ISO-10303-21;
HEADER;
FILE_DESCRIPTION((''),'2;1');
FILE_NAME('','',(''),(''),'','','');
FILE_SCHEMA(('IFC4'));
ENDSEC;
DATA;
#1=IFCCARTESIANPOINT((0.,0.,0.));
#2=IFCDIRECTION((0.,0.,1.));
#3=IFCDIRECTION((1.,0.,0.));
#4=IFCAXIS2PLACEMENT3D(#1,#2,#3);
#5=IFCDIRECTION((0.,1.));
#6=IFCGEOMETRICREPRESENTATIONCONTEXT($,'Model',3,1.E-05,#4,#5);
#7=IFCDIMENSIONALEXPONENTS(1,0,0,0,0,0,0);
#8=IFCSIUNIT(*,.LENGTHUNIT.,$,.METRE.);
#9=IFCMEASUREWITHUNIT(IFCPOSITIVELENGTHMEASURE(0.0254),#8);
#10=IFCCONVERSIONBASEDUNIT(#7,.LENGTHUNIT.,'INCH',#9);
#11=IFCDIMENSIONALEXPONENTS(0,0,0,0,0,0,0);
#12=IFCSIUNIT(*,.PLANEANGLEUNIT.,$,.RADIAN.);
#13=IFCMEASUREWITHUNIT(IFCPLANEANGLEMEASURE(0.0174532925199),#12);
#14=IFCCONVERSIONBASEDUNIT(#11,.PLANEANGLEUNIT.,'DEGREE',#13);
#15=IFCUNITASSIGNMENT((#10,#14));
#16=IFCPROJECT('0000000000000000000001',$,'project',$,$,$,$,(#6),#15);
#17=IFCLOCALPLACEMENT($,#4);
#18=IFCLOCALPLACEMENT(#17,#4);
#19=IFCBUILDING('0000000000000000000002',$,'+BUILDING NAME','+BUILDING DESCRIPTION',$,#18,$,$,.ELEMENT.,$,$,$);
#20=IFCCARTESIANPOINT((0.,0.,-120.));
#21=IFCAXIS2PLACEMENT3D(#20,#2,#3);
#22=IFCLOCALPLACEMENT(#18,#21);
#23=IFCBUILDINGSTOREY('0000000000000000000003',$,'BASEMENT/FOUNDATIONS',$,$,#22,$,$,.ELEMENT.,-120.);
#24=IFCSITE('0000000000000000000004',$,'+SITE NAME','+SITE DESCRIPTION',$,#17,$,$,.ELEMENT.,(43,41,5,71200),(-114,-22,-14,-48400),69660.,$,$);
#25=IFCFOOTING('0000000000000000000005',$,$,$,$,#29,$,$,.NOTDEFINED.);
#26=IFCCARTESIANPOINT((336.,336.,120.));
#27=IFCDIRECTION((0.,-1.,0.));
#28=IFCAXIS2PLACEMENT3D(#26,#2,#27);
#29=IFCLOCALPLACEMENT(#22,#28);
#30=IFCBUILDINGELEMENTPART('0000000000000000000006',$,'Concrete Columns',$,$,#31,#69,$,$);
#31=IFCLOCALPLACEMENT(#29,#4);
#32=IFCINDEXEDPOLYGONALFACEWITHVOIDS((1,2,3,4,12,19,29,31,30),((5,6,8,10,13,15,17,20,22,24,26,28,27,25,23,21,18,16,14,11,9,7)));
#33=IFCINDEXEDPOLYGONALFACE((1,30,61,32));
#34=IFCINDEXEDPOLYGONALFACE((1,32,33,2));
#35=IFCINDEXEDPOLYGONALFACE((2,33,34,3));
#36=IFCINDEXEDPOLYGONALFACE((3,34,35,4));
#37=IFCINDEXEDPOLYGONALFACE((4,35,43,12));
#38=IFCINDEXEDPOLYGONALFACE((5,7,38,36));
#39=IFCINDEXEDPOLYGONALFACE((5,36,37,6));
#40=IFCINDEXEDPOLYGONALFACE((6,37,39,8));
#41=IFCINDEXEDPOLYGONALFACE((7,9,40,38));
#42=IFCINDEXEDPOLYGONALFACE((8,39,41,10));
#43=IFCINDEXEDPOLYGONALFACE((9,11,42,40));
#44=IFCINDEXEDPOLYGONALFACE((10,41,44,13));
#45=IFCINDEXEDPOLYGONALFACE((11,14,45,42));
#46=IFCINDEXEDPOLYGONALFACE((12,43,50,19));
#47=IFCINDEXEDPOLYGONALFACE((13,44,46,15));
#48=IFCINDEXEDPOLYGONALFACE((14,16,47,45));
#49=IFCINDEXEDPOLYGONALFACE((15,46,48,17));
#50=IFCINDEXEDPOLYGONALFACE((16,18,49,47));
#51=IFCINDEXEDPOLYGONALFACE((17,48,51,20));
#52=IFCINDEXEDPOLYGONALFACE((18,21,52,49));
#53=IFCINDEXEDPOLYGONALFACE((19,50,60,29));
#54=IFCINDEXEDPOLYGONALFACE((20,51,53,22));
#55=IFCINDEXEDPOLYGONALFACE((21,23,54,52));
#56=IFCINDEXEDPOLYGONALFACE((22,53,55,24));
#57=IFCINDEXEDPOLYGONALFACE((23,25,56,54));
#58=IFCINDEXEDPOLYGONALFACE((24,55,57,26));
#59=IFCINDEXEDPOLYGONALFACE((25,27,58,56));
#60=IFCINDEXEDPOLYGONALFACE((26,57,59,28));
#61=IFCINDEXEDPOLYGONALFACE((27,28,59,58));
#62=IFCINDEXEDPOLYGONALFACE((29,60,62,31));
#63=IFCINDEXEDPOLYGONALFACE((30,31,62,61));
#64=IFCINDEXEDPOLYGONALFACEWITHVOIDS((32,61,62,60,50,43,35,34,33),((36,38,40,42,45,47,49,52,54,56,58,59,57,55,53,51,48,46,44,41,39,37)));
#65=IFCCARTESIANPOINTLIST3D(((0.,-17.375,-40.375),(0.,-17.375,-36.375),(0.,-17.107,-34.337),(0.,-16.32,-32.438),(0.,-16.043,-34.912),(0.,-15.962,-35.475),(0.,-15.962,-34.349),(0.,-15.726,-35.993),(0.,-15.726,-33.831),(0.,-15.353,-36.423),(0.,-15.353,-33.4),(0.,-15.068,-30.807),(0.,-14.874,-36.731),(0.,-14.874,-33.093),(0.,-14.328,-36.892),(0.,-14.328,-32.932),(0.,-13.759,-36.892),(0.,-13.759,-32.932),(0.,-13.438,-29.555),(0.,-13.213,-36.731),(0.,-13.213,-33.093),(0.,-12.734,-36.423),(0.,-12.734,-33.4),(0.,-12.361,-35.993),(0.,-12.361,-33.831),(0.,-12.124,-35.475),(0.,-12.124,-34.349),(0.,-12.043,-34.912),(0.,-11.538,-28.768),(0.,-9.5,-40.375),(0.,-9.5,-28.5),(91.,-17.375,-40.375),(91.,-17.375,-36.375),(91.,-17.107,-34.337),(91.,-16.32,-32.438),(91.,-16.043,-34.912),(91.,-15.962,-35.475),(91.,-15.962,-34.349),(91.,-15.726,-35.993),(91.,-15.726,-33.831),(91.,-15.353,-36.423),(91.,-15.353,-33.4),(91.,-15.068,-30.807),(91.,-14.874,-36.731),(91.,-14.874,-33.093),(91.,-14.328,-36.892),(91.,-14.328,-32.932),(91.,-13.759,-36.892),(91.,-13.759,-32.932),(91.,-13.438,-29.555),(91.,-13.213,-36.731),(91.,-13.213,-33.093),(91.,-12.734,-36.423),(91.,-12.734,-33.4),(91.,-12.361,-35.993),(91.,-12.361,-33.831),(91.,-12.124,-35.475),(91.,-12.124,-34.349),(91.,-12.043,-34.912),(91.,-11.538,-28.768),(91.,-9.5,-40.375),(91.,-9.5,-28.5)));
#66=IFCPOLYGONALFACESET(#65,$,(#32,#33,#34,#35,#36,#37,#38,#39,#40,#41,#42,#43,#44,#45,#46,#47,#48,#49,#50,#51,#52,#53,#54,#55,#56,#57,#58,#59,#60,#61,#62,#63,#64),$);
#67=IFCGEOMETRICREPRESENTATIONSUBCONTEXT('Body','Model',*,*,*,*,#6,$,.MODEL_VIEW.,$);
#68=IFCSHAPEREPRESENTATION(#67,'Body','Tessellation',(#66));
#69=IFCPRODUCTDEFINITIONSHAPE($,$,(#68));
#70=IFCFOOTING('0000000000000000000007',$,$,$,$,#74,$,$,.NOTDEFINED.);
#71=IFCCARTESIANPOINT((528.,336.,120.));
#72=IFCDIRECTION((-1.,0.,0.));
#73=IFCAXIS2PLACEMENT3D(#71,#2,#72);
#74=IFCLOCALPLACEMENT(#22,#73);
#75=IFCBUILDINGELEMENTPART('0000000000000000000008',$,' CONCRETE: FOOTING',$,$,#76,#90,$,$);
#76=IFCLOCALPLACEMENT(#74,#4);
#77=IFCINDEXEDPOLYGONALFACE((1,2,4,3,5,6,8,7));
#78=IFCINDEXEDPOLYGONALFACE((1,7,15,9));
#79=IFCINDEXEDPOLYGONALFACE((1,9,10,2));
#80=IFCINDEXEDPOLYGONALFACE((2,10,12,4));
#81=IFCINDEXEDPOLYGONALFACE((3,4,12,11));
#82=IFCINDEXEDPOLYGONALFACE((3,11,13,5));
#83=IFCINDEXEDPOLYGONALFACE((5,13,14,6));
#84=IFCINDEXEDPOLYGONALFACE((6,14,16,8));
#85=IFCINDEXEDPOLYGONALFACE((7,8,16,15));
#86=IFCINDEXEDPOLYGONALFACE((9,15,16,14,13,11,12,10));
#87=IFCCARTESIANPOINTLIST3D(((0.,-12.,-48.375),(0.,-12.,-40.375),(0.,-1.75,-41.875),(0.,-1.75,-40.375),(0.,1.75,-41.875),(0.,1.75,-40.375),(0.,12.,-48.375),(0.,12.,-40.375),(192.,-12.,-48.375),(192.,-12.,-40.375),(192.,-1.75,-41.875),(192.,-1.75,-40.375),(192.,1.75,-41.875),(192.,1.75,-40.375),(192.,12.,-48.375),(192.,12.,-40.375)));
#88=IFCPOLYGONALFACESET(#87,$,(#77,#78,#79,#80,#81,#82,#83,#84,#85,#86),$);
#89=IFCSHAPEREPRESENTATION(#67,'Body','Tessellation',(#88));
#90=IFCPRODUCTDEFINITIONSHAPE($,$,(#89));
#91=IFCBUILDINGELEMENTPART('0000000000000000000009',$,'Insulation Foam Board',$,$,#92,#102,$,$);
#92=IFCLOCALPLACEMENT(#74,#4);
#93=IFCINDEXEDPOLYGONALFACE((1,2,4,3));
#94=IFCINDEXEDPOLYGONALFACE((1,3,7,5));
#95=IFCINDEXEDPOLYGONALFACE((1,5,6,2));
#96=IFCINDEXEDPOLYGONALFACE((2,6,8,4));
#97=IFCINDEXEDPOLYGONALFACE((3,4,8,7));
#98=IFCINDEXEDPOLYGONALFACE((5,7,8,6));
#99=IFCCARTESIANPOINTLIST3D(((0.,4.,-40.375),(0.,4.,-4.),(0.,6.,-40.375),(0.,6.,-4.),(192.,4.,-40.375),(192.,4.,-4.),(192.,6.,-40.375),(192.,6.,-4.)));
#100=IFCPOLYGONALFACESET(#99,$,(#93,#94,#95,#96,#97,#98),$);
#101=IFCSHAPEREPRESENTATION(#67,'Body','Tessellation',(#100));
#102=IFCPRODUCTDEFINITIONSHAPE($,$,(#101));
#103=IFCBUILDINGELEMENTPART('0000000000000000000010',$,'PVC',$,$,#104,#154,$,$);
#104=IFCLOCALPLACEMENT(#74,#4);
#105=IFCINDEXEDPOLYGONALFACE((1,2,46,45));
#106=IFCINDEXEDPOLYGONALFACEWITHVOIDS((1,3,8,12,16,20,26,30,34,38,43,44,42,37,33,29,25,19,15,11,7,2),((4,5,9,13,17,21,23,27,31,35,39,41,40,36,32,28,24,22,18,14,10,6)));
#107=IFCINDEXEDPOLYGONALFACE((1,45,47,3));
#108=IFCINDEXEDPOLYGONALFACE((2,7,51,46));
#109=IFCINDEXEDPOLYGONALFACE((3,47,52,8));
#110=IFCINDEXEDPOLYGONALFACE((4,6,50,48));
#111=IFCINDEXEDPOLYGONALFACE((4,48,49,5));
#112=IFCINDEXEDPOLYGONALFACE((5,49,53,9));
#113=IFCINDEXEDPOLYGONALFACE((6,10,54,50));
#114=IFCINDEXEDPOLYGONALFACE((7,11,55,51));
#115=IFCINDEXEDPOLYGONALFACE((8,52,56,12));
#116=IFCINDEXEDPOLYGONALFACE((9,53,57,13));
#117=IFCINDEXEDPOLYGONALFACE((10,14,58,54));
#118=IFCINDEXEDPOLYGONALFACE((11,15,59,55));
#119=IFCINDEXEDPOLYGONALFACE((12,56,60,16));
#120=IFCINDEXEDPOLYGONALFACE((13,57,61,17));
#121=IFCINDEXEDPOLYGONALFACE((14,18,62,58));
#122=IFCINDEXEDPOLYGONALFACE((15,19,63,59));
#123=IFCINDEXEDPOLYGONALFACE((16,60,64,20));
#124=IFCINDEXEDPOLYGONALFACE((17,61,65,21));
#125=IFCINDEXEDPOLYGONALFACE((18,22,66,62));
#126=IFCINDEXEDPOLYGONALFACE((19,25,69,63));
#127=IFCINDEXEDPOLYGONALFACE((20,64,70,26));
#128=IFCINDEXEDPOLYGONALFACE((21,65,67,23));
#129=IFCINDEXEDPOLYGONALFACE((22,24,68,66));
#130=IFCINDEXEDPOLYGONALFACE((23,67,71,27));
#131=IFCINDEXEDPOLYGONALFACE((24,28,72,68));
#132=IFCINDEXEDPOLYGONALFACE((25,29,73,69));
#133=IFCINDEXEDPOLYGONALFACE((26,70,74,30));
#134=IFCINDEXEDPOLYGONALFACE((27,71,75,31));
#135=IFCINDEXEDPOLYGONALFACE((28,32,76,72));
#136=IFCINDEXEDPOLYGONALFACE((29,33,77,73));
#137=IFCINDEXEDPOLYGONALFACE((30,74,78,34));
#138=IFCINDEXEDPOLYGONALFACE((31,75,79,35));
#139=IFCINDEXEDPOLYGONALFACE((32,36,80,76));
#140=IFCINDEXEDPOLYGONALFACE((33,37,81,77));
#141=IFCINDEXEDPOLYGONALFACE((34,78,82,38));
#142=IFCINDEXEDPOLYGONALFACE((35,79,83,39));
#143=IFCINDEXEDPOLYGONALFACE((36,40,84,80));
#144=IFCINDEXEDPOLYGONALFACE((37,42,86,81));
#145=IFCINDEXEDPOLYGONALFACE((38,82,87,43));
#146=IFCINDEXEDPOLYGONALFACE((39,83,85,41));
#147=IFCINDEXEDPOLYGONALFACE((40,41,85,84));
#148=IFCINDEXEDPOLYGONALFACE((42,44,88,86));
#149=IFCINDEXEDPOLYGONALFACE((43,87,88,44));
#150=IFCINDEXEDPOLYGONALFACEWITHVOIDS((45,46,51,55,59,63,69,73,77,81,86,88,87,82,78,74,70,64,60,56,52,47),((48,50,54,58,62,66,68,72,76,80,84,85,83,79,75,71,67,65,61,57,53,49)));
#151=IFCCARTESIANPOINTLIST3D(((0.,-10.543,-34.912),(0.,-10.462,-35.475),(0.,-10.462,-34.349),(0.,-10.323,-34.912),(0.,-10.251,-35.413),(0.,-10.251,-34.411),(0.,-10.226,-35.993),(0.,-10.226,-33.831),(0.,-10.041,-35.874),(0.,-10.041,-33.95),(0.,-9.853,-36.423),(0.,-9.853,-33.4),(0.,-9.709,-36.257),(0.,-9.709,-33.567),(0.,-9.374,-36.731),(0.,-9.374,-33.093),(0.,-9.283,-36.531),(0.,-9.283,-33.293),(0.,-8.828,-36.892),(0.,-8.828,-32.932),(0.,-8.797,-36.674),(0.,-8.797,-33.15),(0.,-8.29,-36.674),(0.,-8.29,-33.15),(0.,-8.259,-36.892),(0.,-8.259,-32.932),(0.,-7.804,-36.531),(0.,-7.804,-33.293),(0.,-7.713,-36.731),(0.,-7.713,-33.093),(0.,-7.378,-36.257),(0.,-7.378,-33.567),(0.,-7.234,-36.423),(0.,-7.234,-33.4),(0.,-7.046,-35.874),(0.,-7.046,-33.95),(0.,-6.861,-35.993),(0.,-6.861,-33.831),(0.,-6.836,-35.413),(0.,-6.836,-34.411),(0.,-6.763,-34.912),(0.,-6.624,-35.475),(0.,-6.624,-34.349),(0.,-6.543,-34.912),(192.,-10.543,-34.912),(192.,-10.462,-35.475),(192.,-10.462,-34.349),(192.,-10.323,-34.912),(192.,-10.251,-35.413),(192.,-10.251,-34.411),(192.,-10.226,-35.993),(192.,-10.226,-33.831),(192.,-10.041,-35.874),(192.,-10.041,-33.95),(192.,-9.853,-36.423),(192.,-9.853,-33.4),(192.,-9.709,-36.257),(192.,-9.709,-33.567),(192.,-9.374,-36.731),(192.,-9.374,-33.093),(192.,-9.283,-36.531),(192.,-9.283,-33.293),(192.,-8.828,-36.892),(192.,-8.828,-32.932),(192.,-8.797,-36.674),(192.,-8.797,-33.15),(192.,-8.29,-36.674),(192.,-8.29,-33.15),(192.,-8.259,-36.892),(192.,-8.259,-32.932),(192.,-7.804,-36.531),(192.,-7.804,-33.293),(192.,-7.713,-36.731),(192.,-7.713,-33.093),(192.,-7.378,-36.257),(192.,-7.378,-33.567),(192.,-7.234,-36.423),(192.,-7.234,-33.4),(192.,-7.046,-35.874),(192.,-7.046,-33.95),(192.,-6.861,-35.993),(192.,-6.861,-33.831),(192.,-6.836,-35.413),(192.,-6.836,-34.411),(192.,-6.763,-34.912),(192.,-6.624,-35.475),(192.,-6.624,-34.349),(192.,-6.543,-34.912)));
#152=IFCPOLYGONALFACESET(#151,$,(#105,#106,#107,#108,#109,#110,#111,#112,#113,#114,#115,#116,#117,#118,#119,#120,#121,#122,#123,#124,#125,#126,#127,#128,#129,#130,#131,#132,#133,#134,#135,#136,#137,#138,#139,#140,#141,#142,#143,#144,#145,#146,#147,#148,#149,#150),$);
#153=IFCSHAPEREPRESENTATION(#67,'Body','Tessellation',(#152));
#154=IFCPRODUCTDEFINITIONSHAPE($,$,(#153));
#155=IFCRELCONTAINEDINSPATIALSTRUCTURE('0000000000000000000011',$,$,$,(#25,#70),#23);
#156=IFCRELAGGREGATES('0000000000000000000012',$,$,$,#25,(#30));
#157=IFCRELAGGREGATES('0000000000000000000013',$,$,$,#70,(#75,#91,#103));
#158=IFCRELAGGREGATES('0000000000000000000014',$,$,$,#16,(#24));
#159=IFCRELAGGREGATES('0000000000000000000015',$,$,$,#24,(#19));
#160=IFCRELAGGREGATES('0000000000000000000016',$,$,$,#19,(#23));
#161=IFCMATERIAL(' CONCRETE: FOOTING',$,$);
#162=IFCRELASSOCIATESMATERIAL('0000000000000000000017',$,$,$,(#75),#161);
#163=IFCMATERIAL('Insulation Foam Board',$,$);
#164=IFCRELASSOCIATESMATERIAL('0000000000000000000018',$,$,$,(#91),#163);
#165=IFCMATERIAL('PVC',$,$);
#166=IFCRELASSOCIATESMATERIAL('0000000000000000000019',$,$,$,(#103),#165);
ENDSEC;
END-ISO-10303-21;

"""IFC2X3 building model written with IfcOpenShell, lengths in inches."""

from ifc_helpers import new_model, entity, si_unit, converted_unit, point, direction, frame, frame_2d, origin_with_axes, place, context, subcontext, project, spatial, polyline, circle_curve, parameter, trimmed, segment, composite_curve, outline, extrude, material, element, aggregate, save


model = new_model("IFC2X3")

# Units and contexts
model_context = context("Model", 3, precision=1e-05, world=origin_with_axes(), true_north=direction((0.0, 1.0)))
body_context = subcontext(model_context, "Body", "Model", "MODEL_VIEW")
ifc_project = project(units=[converted_unit("LENGTHUNIT", "INCH", entity("IfcPositiveLengthMeasure", 0.0254), si_unit("LENGTHUNIT", "METRE"), dimensions=[1, 0, 0, 0, 0, 0, 0]), converted_unit("PLANEANGLEUNIT", "DEGREE", entity("IfcPlaneAngleMeasure", 0.0174532925199), si_unit("PLANEANGLEUNIT", "RADIAN"), dimensions=[0, 0, 0, 0, 0, 0, 0])], contexts=[model_context])

# Site, building, storey
site_placement = place(None, origin_with_axes())
site = spatial("IfcSite", under=ifc_project, at=site_placement, Name="+SITE NAME", Description="+SITE DESCRIPTION", CompositionType="ELEMENT", RefLatitude=(43, 41, 5, 71200), RefLongitude=(-114, -22, -14, -48400), RefElevation=69660.0)
building_placement = place(site_placement, origin_with_axes())
building = spatial("IfcBuilding", under=site, at=building_placement, Name="+BUILDING NAME", Description="+BUILDING DESCRIPTION", CompositionType="ELEMENT")
storey_placement = place(building_placement, frame((0.0, 0.0, -120.0), z_axis=(0.0, 0.0, 1.0), x_axis=(1.0, 0.0, 0.0)))
storey = spatial("IfcBuildingStorey", under=building, at=storey_placement, Name="BASEMENT/FOUNDATIONS", CompositionType="ELEMENT", Elevation=-120.0)

# Footings, building element parts
ifc_material_1 = material(Name=" CONCRETE: FOOTING")
ifc_material_2 = material(Name="Insulation Foam Board")
ifc_material_3 = material(Name="PVC")
footing_1_placement = place(storey_placement, frame((336.0, 336.0, 120.0), z_axis=(0.0, 0.0, 1.0), x_axis=(0.0, -1.0, 0.0)))
footing_1 = element("IfcFooting", 1, at=footing_1_placement, inside=storey, PredefinedType="NOTDEFINED")
building_element_part_1_placement = place(footing_1_placement, origin_with_axes())
building_element_part_1 = element("IfcBuildingElementPart", 2, at=building_element_part_1_placement, Name="Concrete Columns", context=body_context, shape_type="SweptSolid", body=[
    extrude(outline(composite_curve([segment(trimmed(circle_curve(frame_2d((9.5, -36.375), x_axis=(1.0, 0.0)), 7.875), [point((17.375, -36.375)), parameter(0.0)], [point((9.5, -28.5)), parameter(90.0)], True, "CARTESIAN"), True, "CONTINUOUS"), segment(polyline([(9.5, -28.5), (9.5, -40.375), (17.375, -40.375), (17.375, -36.375)]), True, "CONTINUOUS")], self_intersect=False), holes=[composite_curve([segment(trimmed(circle_curve(frame_2d((14.043, -34.912), x_axis=(-1.0, 0.0)), 2.0), [point((16.043, -34.912)), parameter(180.0)], [point((12.043, -34.912)), parameter(0.0)], False, "CARTESIAN"), True, "CONTINUOUS"), segment(trimmed(circle_curve(frame_2d((14.043, -34.912), x_axis=(1.0, 0.0)), 2.0), [point((12.043, -34.912)), parameter(180.0)], [point((16.043, -34.912)), parameter(0.0)], False, "CARTESIAN"), True, "CONTINUOUS")], self_intersect=False)]), frame((0.0, 0.0, 0.0), z_axis=(-1.0, 0.0, 0.0), x_axis=(0.0, -1.0, 0.0)), (0.0, 0.0, -1.0), 91.0),
])
aggregate(footing_1, [building_element_part_1])
footing_2_placement = place(storey_placement, frame((528.0, 336.0, 120.0), z_axis=(0.0, 0.0, 1.0), x_axis=(-1.0, 0.0, 0.0)))
footing_2 = element("IfcFooting", 3, at=footing_2_placement, inside=storey, PredefinedType="NOTDEFINED")
building_element_part_2_placement = place(footing_2_placement, origin_with_axes())
building_element_part_2 = element("IfcBuildingElementPart", 4, at=building_element_part_2_placement, material=ifc_material_1, Name=" CONCRETE: FOOTING", context=body_context, shape_type="SweptSolid", body=[
    extrude(outline(polyline([(-12.0, -48.375), (12.0, -48.375), (12.0, -40.375), (1.75, -40.375), (1.75, -41.875), (-1.75, -41.875), (-1.75, -40.375), (-12.0, -40.375), (-12.0, -48.375)])), frame((0.0, 0.0, 0.0), z_axis=(-1.0, 0.0, 0.0), x_axis=(0.0, -1.0, 0.0)), (0.0, 0.0, -1.0), 192.0),
])
building_element_part_3_placement = place(footing_2_placement, origin_with_axes())
building_element_part_3 = element("IfcBuildingElementPart", 5, at=building_element_part_3_placement, material=ifc_material_2, Name="Insulation Foam Board", context=body_context, shape_type="SweptSolid", body=[
    extrude(outline(polyline([(-4.0, -4.0), (-6.0, -4.0), (-6.0, -40.375), (-4.0, -40.375), (-4.0, -4.0)])), frame((0.0, 0.0, 0.0), z_axis=(-1.0, 0.0, 0.0), x_axis=(0.0, -1.0, 0.0)), (0.0, 0.0, -1.0), 192.0),
])
building_element_part_4_placement = place(footing_2_placement, origin_with_axes())
building_element_part_4 = element("IfcBuildingElementPart", 6, at=building_element_part_4_placement, material=ifc_material_3, Name="PVC", context=body_context, shape_type="SweptSolid", body=[
    extrude(outline(composite_curve([segment(trimmed(circle_curve(frame_2d((8.543, -34.912), x_axis=(1.0, 0.0)), 2.0), [point((10.543, -34.912)), parameter(0.0)], [point((6.543, -34.912)), parameter(180.0)], True, "CARTESIAN"), True, "CONTINUOUS"), segment(trimmed(circle_curve(frame_2d((8.543, -34.912), x_axis=(-1.0, 0.0)), 2.0), [point((6.543, -34.912)), parameter(0.0)], [point((10.543, -34.912)), parameter(180.0)], True, "CARTESIAN"), True, "CONTINUOUS")], self_intersect=False), holes=[composite_curve([segment(trimmed(circle_curve(frame_2d((8.543, -34.912), x_axis=(-1.0, 0.0)), 1.78), [point((10.323, -34.912)), parameter(180.0)], [point((6.763, -34.912)), parameter(0.0)], False, "CARTESIAN"), True, "CONTINUOUS"), segment(trimmed(circle_curve(frame_2d((8.543, -34.912), x_axis=(1.0, 0.0)), 1.78), [point((6.763, -34.912)), parameter(180.0)], [point((10.323, -34.912)), parameter(0.0)], False, "CARTESIAN"), True, "CONTINUOUS")], self_intersect=False)]), frame((0.0, 0.0, 0.0), z_axis=(-1.0, 0.0, 0.0), x_axis=(0.0, -1.0, 0.0)), (0.0, 0.0, -1.0), 192.0),
])
aggregate(footing_2, [building_element_part_2, building_element_part_3, building_element_part_4])

save(model, "model.ifc")
